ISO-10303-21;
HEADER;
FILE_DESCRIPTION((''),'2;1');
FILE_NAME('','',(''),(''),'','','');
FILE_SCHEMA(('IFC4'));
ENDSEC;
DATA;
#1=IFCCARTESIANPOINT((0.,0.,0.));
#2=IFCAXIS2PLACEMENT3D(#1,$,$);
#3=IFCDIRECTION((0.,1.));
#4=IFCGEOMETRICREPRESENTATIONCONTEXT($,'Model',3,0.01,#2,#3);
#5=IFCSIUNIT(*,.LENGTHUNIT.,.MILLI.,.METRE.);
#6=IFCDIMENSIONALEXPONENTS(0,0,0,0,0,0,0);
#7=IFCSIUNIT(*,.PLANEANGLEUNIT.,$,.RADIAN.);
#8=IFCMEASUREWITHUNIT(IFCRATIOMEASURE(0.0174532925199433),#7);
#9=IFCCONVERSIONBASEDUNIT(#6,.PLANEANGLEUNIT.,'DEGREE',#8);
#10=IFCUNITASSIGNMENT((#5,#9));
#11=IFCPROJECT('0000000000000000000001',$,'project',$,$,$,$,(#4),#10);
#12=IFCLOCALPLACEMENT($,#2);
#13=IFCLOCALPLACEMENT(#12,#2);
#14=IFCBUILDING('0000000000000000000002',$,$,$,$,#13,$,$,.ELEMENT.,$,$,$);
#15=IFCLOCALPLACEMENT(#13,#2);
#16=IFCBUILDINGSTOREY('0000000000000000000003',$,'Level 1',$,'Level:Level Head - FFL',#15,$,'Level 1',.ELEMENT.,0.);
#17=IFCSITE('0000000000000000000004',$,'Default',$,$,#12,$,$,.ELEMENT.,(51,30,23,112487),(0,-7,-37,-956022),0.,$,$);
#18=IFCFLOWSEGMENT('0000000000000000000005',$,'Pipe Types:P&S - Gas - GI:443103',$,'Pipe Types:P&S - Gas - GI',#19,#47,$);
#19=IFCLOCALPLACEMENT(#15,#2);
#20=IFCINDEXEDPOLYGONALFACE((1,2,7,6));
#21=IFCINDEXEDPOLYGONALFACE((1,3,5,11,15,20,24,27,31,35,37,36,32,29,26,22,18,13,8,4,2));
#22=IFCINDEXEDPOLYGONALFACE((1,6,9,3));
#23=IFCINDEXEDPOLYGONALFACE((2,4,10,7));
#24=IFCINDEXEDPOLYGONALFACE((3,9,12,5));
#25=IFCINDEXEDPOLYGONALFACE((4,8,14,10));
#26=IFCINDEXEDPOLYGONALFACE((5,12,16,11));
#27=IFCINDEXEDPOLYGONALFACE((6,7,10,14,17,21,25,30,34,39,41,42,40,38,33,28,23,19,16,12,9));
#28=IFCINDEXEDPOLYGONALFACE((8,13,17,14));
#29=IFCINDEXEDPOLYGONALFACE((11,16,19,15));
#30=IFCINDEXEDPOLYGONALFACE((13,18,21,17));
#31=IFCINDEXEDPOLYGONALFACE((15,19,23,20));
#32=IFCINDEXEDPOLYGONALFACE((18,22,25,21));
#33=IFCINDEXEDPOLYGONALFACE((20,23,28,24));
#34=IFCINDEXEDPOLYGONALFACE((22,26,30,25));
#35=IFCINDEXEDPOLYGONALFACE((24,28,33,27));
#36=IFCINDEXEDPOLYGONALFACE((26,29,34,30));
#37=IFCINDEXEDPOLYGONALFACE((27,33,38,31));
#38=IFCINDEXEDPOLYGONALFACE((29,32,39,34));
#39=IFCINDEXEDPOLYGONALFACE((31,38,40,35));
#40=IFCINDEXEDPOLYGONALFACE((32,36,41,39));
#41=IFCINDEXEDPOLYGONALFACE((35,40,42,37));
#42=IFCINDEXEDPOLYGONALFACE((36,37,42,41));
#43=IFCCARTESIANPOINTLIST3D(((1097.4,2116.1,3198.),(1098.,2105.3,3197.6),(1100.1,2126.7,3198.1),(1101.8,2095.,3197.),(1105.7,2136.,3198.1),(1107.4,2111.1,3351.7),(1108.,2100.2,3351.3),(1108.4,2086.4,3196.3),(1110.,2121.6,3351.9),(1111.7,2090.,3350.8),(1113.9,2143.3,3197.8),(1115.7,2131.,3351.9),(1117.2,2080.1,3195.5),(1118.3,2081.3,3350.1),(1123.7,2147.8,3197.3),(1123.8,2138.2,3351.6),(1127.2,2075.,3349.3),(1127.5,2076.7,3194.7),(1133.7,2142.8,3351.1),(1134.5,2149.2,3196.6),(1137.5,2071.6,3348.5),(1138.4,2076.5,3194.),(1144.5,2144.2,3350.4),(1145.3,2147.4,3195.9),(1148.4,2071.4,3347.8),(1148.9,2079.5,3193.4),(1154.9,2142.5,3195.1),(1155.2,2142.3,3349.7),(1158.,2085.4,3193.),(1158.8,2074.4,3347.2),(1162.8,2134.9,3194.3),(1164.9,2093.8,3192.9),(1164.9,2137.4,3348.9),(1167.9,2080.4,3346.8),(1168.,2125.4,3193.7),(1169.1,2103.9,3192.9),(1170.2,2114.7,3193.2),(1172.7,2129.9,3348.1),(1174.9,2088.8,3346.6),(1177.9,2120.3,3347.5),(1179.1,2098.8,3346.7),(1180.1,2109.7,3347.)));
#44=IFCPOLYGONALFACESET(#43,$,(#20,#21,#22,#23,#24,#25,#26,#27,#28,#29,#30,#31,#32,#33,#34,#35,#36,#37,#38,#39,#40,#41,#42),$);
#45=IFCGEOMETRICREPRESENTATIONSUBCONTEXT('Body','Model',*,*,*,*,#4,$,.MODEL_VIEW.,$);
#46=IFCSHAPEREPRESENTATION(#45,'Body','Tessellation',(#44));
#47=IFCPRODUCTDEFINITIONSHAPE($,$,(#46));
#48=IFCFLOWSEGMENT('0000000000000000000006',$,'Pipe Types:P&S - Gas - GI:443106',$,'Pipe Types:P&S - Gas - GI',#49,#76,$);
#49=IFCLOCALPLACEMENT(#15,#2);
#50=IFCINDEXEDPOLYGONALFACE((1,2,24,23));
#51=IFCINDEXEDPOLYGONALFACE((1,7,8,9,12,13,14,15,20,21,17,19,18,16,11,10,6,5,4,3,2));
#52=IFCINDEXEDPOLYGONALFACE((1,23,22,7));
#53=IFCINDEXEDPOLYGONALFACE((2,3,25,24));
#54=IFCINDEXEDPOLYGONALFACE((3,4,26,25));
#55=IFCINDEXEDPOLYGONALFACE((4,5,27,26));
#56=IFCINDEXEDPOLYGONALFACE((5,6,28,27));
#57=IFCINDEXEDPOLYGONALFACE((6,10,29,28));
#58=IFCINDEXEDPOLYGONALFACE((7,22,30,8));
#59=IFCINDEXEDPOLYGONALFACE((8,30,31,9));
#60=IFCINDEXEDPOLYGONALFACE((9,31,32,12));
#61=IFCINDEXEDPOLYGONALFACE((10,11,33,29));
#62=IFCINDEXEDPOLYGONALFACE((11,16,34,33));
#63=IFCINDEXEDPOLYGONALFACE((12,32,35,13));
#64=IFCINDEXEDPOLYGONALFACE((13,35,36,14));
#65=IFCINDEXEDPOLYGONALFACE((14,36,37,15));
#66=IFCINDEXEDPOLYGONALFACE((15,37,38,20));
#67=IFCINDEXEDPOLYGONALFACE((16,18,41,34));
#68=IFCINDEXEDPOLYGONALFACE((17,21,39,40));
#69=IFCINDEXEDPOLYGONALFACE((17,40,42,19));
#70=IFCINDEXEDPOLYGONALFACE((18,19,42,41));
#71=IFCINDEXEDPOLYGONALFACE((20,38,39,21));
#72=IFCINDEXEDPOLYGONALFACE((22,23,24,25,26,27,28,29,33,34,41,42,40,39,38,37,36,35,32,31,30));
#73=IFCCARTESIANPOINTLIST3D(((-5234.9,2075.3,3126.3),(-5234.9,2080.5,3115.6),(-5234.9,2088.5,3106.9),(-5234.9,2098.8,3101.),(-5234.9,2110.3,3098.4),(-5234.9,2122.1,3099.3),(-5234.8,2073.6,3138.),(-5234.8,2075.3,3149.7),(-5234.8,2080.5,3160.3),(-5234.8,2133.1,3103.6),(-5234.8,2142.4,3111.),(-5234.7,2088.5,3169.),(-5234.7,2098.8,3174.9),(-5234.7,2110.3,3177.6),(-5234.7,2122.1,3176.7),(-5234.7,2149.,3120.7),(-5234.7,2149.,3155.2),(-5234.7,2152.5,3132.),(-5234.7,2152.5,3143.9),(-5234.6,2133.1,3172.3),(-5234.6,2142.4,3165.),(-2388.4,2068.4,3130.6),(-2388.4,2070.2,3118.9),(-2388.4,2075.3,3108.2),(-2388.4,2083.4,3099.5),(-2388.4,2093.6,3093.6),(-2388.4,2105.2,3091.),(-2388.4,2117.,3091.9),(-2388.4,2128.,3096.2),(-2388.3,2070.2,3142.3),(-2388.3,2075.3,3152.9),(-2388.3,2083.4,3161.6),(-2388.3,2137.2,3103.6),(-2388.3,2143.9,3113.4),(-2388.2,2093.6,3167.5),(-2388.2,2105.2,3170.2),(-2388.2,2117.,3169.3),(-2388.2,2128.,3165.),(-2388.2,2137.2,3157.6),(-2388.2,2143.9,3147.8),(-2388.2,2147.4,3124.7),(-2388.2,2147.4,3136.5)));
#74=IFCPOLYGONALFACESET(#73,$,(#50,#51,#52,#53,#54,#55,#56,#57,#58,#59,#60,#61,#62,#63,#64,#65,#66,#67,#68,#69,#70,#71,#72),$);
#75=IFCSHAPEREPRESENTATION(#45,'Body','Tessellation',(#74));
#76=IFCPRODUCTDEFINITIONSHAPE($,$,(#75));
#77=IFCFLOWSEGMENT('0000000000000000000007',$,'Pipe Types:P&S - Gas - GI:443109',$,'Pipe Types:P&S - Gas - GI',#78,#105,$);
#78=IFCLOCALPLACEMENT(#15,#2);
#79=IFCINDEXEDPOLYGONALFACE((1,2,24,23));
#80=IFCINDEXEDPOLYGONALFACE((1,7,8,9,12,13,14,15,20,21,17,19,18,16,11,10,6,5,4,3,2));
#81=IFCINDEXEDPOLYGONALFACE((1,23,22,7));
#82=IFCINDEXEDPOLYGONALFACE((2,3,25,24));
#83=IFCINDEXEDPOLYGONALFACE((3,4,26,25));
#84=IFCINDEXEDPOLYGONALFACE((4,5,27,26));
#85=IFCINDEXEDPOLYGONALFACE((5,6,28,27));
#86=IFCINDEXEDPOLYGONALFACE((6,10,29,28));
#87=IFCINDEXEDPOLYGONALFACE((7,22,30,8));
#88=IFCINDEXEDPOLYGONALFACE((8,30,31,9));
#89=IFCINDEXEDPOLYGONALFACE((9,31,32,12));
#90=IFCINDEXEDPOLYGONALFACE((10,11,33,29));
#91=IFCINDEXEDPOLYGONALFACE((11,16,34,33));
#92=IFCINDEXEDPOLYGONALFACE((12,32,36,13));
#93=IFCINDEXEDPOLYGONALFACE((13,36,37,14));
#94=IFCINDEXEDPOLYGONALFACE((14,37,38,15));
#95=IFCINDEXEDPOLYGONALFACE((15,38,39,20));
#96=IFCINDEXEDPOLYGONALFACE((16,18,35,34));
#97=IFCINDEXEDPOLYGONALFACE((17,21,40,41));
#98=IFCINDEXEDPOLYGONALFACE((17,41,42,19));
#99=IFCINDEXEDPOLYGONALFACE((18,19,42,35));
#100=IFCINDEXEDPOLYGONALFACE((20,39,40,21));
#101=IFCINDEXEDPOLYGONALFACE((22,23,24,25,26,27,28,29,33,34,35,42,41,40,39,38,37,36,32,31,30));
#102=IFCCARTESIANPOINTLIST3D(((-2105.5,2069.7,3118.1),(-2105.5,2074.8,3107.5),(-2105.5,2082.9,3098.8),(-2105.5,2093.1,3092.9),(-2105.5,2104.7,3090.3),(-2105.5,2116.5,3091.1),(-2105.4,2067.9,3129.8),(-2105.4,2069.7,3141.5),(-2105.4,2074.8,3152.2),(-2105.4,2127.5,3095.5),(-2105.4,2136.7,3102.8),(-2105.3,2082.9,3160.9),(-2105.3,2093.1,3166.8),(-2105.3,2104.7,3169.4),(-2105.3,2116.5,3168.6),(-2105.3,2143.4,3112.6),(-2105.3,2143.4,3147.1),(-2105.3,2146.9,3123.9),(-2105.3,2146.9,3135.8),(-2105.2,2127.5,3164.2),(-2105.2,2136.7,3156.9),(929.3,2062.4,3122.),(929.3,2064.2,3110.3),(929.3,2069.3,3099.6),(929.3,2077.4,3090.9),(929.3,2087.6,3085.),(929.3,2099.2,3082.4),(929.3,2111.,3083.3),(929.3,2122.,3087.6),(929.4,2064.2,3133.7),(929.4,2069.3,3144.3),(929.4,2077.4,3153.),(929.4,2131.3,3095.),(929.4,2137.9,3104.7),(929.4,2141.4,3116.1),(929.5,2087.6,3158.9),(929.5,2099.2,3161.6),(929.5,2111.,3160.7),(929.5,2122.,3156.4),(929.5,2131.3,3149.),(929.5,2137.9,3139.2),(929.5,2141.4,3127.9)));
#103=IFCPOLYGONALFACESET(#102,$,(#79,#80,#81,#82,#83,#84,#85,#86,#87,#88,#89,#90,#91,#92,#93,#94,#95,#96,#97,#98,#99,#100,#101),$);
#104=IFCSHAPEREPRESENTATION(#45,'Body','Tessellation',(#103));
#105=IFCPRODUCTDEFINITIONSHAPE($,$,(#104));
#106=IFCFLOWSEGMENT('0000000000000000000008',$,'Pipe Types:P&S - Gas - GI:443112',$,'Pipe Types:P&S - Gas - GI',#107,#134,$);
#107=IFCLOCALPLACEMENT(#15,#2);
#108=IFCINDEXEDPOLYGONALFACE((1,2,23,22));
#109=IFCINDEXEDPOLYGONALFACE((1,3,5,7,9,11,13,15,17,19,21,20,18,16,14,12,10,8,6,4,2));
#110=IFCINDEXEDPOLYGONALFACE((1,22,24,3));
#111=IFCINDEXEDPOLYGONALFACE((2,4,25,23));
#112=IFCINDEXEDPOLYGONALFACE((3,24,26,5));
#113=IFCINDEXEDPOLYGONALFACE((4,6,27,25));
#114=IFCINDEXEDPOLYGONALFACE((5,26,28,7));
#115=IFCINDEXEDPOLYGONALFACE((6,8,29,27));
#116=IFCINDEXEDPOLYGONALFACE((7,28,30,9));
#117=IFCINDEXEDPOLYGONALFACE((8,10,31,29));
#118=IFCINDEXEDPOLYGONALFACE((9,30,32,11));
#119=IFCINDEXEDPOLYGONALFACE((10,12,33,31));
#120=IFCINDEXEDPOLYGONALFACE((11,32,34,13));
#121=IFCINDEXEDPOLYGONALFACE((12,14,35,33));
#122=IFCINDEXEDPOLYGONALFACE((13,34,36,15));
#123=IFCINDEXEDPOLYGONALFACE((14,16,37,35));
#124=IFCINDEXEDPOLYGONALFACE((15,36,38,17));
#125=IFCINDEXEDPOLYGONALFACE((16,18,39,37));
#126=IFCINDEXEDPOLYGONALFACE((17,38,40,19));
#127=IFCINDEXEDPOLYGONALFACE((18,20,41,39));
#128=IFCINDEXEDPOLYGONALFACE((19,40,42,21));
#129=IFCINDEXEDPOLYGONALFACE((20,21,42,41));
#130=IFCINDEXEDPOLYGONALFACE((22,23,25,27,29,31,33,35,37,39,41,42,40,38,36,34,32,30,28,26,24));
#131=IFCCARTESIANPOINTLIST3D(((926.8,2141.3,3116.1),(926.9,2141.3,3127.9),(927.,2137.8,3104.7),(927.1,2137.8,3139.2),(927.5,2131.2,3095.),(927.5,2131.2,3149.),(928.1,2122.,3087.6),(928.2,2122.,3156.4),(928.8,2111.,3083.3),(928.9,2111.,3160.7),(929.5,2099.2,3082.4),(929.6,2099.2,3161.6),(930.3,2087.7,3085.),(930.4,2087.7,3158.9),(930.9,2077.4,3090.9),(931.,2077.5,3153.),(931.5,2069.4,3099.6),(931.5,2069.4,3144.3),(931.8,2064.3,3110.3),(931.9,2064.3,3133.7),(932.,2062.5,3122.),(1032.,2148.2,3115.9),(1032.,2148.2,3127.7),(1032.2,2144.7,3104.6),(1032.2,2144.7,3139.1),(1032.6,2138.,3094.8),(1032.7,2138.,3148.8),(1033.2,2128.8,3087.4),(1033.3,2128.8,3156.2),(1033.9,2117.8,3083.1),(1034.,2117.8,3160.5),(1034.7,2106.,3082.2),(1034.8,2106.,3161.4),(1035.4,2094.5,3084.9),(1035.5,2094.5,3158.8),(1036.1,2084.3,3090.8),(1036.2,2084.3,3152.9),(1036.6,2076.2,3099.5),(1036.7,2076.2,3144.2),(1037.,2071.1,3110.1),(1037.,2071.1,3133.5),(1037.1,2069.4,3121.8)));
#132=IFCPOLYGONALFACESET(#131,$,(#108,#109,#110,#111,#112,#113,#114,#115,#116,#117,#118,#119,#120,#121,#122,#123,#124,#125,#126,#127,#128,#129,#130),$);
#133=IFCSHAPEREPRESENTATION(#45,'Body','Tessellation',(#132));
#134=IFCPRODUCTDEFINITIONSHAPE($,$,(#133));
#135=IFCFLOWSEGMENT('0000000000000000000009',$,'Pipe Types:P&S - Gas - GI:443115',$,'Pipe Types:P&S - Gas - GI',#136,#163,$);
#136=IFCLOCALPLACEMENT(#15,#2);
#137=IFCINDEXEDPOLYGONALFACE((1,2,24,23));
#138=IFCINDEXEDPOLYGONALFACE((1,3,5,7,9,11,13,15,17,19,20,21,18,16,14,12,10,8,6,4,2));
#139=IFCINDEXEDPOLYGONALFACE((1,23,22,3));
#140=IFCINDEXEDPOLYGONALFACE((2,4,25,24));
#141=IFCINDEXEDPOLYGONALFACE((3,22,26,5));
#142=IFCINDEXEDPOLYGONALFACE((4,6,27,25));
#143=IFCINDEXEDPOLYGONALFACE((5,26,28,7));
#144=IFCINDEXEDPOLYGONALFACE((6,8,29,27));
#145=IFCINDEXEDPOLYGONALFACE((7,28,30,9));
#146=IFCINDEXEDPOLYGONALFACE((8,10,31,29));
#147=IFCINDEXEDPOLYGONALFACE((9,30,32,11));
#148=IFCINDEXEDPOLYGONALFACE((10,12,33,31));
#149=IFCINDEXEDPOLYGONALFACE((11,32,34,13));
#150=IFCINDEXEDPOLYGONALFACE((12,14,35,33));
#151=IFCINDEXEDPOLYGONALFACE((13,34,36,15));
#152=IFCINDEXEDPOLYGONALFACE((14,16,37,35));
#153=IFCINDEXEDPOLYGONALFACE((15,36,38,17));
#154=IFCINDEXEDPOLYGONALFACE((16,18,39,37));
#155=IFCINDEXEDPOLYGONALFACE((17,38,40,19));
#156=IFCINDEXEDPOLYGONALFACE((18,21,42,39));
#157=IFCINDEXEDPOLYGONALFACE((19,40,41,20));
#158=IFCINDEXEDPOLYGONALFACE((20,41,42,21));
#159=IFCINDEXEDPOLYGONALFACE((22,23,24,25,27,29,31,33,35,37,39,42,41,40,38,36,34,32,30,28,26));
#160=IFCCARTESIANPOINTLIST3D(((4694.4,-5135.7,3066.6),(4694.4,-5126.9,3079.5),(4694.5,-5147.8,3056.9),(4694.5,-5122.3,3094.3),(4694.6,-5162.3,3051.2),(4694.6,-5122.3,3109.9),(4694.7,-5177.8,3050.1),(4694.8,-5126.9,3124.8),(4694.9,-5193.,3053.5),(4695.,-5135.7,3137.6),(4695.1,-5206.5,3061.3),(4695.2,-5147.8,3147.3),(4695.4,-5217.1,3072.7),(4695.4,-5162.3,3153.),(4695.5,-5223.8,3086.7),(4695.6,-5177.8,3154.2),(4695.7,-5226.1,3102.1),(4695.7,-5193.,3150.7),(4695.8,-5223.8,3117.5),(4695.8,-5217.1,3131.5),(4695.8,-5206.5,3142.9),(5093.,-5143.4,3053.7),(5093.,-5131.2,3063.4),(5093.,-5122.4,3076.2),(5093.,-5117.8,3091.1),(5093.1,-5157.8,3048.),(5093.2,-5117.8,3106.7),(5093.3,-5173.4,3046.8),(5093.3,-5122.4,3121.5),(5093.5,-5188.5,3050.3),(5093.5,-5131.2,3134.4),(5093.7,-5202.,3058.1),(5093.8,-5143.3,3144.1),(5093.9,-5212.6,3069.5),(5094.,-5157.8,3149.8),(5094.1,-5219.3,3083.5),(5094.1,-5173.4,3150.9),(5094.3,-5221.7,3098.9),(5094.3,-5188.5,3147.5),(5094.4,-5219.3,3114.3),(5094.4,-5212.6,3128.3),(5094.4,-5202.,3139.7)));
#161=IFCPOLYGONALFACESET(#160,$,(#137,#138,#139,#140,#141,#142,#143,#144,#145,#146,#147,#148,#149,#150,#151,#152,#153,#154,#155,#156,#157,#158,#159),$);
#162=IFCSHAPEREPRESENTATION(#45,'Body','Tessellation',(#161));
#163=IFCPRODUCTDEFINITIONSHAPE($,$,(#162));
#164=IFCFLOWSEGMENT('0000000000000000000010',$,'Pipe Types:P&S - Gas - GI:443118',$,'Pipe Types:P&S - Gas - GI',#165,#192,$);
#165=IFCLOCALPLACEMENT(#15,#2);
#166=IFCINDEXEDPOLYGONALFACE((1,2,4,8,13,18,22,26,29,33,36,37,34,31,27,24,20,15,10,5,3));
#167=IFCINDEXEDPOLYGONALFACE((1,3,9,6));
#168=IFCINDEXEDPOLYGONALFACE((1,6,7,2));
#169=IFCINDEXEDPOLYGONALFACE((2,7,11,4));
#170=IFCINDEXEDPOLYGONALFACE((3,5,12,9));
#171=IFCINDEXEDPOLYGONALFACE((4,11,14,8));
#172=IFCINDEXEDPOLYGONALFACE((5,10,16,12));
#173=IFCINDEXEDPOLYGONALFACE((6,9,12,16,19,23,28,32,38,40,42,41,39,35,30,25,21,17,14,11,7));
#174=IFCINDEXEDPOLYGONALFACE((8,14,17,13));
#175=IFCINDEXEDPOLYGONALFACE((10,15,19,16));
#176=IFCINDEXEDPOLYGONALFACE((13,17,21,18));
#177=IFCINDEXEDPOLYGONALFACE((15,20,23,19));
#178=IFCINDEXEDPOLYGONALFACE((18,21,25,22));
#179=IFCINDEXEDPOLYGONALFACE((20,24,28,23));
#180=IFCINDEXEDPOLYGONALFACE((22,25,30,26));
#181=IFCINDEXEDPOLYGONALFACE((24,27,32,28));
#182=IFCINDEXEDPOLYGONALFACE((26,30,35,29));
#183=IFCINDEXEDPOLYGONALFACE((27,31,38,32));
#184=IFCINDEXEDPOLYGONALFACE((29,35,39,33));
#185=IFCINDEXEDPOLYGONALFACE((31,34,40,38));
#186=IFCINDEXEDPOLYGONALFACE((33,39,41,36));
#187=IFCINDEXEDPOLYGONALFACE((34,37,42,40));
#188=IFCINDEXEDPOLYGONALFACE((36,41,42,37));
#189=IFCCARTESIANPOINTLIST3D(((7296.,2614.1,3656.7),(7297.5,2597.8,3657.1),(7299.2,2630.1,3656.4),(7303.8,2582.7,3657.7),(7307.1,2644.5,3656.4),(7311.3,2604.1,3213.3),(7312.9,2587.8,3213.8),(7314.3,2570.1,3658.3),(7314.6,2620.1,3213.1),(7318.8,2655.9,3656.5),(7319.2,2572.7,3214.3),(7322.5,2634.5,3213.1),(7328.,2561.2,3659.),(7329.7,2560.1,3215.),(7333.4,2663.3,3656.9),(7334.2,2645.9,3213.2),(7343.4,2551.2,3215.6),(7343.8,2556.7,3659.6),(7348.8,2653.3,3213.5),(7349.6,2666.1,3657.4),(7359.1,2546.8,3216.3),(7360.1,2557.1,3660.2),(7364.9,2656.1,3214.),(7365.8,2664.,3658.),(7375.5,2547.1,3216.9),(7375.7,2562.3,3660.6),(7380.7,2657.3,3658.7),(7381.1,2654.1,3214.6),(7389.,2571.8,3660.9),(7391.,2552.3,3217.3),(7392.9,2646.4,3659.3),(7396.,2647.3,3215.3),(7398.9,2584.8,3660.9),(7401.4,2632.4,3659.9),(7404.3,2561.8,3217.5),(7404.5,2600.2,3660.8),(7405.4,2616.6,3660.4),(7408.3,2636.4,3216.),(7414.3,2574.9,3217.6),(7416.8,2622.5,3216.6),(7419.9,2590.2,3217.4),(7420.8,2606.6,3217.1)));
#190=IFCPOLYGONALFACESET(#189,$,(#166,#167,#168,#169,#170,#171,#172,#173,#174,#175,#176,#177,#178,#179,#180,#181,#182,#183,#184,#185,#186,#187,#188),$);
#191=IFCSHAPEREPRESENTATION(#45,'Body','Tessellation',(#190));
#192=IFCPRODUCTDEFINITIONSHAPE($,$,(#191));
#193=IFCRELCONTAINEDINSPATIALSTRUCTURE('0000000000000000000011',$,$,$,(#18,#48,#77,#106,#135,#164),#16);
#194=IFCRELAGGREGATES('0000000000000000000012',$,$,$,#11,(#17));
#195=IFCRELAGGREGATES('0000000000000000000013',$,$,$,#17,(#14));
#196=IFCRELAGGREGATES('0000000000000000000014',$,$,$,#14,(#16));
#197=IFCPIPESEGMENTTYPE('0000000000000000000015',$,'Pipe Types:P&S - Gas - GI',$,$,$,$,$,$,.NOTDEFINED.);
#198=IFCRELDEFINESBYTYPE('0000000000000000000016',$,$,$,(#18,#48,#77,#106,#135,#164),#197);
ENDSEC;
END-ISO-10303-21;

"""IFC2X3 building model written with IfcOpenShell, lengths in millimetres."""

from ifc_helpers import new_model, entity, si_unit, converted_unit, direction, frame, frame_2d, origin, origin_2d_with_axis, place, context, subcontext, project, spatial, circle, extrude, type_object, element, save


model = new_model("IFC2X3")

# Units and contexts
model_context = context("Model", 3, precision=0.01, world=origin(), true_north=direction((0.0, 1.0)))
body_context = subcontext(model_context, "Body", "Model", "MODEL_VIEW")
ifc_project = project(units=[si_unit("LENGTHUNIT", "METRE", prefix="MILLI"), converted_unit("PLANEANGLEUNIT", "DEGREE", entity("IfcRatioMeasure", 0.0174532925199433), si_unit("PLANEANGLEUNIT", "RADIAN"), dimensions=[0, 0, 0, 0, 0, 0, 0])], contexts=[model_context])

# Site, building, storey
site_placement = place(None, origin())
site = spatial("IfcSite", under=ifc_project, at=site_placement, Name="Default", CompositionType="ELEMENT", RefLatitude=(51, 30, 23, 112487), RefLongitude=(0, -7, -37, -956022), RefElevation=0.0)
building_placement = place(site_placement, origin())
building = spatial("IfcBuilding", under=site, at=building_placement, CompositionType="ELEMENT")
storey_placement = place(building_placement, origin())
storey = spatial("IfcBuildingStorey", under=building, at=storey_placement, Name="Level 1", ObjectType="Level:Level Head - FFL", LongName="Level 1", CompositionType="ELEMENT", Elevation=0.0)

# Flow segments
pipe_segment_type = type_object("IfcPipeSegmentType", Name="Pipe Types:P&S - Gas - GI", PredefinedType="NOTDEFINED")
flow_segment_1_placement = place(storey_placement, origin())
element("IfcFlowSegment", 1, at=flow_segment_1_placement, inside=storey, type_object=pipe_segment_type, Name="Pipe Types:P&S - Gas - GI:443103", ObjectType="Pipe Types:P&S - Gas - GI", context=body_context, shape_type="SweptSolid", body=[
    extrude(circle(Radius=36.6, at=origin_2d_with_axis()), frame((1133.7, 2112.7, 3195.5), z_axis=(0.064581, -0.032748, 0.997375), x_axis=(-0.452258, -0.891887, 0.0)), (0.0, 0.0, 1.0), 154.2),
])
flow_segment_2_placement = place(storey_placement, origin())
element("IfcFlowSegment", 2, at=flow_segment_2_placement, inside=storey, type_object=pipe_segment_type, Name="Pipe Types:P&S - Gas - GI:443106", ObjectType="Pipe Types:P&S - Gas - GI", context=body_context, shape_type="SweptSolid", body=[
    extrude(circle(Radius=39.7, at=frame_2d((0.0, 0.0), x_axis=(1.0, 0.0))), frame((-5234.8, 2113.3, 3138.0), z_axis=(0.999995, -0.001805, -0.002594), x_axis=(-0.001805, -0.999998, 0.0)), (0.0, 0.0, 1.0), 2846.5),
])
flow_segment_3_placement = place(storey_placement, origin())
element("IfcFlowSegment", 3, at=flow_segment_3_placement, inside=storey, type_object=pipe_segment_type, Name="Pipe Types:P&S - Gas - GI:443109", ObjectType="Pipe Types:P&S - Gas - GI", context=body_context, shape_type="SweptSolid", body=[
    extrude(circle(Radius=39.7, at=frame_2d((0.0, 0.0), x_axis=(1.0, 0.0))), frame((-2105.4, 2107.6, 3129.8), z_axis=(0.999995, -0.001805, -0.002594), x_axis=(-0.001805, -0.999998, 0.0)), (0.0, 0.0, 1.0), 3034.8),
])
flow_segment_4_placement = place(storey_placement, origin())
element("IfcFlowSegment", 4, at=flow_segment_4_placement, inside=storey, type_object=pipe_segment_type, Name="Pipe Types:P&S - Gas - GI:443112", ObjectType="Pipe Types:P&S - Gas - GI", context=body_context, shape_type="SweptSolid", body=[
    extrude(circle(Radius=39.7, at=frame_2d((0.0, 0.0), x_axis=(1.0, 0.0))), frame((929.4, 2102.2, 3122.0), z_axis=(0.997898, 0.064793, -0.001431), x_axis=(0.064793, -0.997899, 0.0)), (0.0, 0.0, 1.0), 105.4),
])
flow_segment_5_placement = place(storey_placement, origin())
element("IfcFlowSegment", 5, at=flow_segment_5_placement, inside=storey, type_object=pipe_segment_type, Name="Pipe Types:P&S - Gas - GI:443115", ObjectType="Pipe Types:P&S - Gas - GI", context=body_context, shape_type="SweptSolid", body=[
    extrude(circle(Radius=52.2, at=origin_2d_with_axis()), frame((4695.1, -5173.9, 3102.1), z_axis=(0.999904, 0.011226, -0.008119), x_axis=(0.011227, -0.999937, 0.0)), (0.0, 0.0, 1.0), 398.6),
])
flow_segment_6_placement = place(storey_placement, origin())
element("IfcFlowSegment", 6, at=flow_segment_6_placement, inside=storey, type_object=pipe_segment_type, Name="Pipe Types:P&S - Gas - GI:443118", ObjectType="Pipe Types:P&S - Gas - GI", context=body_context, shape_type="SweptSolid", body=[
    extrude(circle(Radius=54.9, at=frame_2d((0.0, 0.0), x_axis=(1.0, 0.0))), frame((7350.8, 2611.2, 3658.7), z_axis=(0.034618, -0.022478, -0.999148), x_axis=(0.544584, 0.838706, 0.0)), (0.0, 0.0, 1.0), 443.7),
])

save(model, "model.ifc")
